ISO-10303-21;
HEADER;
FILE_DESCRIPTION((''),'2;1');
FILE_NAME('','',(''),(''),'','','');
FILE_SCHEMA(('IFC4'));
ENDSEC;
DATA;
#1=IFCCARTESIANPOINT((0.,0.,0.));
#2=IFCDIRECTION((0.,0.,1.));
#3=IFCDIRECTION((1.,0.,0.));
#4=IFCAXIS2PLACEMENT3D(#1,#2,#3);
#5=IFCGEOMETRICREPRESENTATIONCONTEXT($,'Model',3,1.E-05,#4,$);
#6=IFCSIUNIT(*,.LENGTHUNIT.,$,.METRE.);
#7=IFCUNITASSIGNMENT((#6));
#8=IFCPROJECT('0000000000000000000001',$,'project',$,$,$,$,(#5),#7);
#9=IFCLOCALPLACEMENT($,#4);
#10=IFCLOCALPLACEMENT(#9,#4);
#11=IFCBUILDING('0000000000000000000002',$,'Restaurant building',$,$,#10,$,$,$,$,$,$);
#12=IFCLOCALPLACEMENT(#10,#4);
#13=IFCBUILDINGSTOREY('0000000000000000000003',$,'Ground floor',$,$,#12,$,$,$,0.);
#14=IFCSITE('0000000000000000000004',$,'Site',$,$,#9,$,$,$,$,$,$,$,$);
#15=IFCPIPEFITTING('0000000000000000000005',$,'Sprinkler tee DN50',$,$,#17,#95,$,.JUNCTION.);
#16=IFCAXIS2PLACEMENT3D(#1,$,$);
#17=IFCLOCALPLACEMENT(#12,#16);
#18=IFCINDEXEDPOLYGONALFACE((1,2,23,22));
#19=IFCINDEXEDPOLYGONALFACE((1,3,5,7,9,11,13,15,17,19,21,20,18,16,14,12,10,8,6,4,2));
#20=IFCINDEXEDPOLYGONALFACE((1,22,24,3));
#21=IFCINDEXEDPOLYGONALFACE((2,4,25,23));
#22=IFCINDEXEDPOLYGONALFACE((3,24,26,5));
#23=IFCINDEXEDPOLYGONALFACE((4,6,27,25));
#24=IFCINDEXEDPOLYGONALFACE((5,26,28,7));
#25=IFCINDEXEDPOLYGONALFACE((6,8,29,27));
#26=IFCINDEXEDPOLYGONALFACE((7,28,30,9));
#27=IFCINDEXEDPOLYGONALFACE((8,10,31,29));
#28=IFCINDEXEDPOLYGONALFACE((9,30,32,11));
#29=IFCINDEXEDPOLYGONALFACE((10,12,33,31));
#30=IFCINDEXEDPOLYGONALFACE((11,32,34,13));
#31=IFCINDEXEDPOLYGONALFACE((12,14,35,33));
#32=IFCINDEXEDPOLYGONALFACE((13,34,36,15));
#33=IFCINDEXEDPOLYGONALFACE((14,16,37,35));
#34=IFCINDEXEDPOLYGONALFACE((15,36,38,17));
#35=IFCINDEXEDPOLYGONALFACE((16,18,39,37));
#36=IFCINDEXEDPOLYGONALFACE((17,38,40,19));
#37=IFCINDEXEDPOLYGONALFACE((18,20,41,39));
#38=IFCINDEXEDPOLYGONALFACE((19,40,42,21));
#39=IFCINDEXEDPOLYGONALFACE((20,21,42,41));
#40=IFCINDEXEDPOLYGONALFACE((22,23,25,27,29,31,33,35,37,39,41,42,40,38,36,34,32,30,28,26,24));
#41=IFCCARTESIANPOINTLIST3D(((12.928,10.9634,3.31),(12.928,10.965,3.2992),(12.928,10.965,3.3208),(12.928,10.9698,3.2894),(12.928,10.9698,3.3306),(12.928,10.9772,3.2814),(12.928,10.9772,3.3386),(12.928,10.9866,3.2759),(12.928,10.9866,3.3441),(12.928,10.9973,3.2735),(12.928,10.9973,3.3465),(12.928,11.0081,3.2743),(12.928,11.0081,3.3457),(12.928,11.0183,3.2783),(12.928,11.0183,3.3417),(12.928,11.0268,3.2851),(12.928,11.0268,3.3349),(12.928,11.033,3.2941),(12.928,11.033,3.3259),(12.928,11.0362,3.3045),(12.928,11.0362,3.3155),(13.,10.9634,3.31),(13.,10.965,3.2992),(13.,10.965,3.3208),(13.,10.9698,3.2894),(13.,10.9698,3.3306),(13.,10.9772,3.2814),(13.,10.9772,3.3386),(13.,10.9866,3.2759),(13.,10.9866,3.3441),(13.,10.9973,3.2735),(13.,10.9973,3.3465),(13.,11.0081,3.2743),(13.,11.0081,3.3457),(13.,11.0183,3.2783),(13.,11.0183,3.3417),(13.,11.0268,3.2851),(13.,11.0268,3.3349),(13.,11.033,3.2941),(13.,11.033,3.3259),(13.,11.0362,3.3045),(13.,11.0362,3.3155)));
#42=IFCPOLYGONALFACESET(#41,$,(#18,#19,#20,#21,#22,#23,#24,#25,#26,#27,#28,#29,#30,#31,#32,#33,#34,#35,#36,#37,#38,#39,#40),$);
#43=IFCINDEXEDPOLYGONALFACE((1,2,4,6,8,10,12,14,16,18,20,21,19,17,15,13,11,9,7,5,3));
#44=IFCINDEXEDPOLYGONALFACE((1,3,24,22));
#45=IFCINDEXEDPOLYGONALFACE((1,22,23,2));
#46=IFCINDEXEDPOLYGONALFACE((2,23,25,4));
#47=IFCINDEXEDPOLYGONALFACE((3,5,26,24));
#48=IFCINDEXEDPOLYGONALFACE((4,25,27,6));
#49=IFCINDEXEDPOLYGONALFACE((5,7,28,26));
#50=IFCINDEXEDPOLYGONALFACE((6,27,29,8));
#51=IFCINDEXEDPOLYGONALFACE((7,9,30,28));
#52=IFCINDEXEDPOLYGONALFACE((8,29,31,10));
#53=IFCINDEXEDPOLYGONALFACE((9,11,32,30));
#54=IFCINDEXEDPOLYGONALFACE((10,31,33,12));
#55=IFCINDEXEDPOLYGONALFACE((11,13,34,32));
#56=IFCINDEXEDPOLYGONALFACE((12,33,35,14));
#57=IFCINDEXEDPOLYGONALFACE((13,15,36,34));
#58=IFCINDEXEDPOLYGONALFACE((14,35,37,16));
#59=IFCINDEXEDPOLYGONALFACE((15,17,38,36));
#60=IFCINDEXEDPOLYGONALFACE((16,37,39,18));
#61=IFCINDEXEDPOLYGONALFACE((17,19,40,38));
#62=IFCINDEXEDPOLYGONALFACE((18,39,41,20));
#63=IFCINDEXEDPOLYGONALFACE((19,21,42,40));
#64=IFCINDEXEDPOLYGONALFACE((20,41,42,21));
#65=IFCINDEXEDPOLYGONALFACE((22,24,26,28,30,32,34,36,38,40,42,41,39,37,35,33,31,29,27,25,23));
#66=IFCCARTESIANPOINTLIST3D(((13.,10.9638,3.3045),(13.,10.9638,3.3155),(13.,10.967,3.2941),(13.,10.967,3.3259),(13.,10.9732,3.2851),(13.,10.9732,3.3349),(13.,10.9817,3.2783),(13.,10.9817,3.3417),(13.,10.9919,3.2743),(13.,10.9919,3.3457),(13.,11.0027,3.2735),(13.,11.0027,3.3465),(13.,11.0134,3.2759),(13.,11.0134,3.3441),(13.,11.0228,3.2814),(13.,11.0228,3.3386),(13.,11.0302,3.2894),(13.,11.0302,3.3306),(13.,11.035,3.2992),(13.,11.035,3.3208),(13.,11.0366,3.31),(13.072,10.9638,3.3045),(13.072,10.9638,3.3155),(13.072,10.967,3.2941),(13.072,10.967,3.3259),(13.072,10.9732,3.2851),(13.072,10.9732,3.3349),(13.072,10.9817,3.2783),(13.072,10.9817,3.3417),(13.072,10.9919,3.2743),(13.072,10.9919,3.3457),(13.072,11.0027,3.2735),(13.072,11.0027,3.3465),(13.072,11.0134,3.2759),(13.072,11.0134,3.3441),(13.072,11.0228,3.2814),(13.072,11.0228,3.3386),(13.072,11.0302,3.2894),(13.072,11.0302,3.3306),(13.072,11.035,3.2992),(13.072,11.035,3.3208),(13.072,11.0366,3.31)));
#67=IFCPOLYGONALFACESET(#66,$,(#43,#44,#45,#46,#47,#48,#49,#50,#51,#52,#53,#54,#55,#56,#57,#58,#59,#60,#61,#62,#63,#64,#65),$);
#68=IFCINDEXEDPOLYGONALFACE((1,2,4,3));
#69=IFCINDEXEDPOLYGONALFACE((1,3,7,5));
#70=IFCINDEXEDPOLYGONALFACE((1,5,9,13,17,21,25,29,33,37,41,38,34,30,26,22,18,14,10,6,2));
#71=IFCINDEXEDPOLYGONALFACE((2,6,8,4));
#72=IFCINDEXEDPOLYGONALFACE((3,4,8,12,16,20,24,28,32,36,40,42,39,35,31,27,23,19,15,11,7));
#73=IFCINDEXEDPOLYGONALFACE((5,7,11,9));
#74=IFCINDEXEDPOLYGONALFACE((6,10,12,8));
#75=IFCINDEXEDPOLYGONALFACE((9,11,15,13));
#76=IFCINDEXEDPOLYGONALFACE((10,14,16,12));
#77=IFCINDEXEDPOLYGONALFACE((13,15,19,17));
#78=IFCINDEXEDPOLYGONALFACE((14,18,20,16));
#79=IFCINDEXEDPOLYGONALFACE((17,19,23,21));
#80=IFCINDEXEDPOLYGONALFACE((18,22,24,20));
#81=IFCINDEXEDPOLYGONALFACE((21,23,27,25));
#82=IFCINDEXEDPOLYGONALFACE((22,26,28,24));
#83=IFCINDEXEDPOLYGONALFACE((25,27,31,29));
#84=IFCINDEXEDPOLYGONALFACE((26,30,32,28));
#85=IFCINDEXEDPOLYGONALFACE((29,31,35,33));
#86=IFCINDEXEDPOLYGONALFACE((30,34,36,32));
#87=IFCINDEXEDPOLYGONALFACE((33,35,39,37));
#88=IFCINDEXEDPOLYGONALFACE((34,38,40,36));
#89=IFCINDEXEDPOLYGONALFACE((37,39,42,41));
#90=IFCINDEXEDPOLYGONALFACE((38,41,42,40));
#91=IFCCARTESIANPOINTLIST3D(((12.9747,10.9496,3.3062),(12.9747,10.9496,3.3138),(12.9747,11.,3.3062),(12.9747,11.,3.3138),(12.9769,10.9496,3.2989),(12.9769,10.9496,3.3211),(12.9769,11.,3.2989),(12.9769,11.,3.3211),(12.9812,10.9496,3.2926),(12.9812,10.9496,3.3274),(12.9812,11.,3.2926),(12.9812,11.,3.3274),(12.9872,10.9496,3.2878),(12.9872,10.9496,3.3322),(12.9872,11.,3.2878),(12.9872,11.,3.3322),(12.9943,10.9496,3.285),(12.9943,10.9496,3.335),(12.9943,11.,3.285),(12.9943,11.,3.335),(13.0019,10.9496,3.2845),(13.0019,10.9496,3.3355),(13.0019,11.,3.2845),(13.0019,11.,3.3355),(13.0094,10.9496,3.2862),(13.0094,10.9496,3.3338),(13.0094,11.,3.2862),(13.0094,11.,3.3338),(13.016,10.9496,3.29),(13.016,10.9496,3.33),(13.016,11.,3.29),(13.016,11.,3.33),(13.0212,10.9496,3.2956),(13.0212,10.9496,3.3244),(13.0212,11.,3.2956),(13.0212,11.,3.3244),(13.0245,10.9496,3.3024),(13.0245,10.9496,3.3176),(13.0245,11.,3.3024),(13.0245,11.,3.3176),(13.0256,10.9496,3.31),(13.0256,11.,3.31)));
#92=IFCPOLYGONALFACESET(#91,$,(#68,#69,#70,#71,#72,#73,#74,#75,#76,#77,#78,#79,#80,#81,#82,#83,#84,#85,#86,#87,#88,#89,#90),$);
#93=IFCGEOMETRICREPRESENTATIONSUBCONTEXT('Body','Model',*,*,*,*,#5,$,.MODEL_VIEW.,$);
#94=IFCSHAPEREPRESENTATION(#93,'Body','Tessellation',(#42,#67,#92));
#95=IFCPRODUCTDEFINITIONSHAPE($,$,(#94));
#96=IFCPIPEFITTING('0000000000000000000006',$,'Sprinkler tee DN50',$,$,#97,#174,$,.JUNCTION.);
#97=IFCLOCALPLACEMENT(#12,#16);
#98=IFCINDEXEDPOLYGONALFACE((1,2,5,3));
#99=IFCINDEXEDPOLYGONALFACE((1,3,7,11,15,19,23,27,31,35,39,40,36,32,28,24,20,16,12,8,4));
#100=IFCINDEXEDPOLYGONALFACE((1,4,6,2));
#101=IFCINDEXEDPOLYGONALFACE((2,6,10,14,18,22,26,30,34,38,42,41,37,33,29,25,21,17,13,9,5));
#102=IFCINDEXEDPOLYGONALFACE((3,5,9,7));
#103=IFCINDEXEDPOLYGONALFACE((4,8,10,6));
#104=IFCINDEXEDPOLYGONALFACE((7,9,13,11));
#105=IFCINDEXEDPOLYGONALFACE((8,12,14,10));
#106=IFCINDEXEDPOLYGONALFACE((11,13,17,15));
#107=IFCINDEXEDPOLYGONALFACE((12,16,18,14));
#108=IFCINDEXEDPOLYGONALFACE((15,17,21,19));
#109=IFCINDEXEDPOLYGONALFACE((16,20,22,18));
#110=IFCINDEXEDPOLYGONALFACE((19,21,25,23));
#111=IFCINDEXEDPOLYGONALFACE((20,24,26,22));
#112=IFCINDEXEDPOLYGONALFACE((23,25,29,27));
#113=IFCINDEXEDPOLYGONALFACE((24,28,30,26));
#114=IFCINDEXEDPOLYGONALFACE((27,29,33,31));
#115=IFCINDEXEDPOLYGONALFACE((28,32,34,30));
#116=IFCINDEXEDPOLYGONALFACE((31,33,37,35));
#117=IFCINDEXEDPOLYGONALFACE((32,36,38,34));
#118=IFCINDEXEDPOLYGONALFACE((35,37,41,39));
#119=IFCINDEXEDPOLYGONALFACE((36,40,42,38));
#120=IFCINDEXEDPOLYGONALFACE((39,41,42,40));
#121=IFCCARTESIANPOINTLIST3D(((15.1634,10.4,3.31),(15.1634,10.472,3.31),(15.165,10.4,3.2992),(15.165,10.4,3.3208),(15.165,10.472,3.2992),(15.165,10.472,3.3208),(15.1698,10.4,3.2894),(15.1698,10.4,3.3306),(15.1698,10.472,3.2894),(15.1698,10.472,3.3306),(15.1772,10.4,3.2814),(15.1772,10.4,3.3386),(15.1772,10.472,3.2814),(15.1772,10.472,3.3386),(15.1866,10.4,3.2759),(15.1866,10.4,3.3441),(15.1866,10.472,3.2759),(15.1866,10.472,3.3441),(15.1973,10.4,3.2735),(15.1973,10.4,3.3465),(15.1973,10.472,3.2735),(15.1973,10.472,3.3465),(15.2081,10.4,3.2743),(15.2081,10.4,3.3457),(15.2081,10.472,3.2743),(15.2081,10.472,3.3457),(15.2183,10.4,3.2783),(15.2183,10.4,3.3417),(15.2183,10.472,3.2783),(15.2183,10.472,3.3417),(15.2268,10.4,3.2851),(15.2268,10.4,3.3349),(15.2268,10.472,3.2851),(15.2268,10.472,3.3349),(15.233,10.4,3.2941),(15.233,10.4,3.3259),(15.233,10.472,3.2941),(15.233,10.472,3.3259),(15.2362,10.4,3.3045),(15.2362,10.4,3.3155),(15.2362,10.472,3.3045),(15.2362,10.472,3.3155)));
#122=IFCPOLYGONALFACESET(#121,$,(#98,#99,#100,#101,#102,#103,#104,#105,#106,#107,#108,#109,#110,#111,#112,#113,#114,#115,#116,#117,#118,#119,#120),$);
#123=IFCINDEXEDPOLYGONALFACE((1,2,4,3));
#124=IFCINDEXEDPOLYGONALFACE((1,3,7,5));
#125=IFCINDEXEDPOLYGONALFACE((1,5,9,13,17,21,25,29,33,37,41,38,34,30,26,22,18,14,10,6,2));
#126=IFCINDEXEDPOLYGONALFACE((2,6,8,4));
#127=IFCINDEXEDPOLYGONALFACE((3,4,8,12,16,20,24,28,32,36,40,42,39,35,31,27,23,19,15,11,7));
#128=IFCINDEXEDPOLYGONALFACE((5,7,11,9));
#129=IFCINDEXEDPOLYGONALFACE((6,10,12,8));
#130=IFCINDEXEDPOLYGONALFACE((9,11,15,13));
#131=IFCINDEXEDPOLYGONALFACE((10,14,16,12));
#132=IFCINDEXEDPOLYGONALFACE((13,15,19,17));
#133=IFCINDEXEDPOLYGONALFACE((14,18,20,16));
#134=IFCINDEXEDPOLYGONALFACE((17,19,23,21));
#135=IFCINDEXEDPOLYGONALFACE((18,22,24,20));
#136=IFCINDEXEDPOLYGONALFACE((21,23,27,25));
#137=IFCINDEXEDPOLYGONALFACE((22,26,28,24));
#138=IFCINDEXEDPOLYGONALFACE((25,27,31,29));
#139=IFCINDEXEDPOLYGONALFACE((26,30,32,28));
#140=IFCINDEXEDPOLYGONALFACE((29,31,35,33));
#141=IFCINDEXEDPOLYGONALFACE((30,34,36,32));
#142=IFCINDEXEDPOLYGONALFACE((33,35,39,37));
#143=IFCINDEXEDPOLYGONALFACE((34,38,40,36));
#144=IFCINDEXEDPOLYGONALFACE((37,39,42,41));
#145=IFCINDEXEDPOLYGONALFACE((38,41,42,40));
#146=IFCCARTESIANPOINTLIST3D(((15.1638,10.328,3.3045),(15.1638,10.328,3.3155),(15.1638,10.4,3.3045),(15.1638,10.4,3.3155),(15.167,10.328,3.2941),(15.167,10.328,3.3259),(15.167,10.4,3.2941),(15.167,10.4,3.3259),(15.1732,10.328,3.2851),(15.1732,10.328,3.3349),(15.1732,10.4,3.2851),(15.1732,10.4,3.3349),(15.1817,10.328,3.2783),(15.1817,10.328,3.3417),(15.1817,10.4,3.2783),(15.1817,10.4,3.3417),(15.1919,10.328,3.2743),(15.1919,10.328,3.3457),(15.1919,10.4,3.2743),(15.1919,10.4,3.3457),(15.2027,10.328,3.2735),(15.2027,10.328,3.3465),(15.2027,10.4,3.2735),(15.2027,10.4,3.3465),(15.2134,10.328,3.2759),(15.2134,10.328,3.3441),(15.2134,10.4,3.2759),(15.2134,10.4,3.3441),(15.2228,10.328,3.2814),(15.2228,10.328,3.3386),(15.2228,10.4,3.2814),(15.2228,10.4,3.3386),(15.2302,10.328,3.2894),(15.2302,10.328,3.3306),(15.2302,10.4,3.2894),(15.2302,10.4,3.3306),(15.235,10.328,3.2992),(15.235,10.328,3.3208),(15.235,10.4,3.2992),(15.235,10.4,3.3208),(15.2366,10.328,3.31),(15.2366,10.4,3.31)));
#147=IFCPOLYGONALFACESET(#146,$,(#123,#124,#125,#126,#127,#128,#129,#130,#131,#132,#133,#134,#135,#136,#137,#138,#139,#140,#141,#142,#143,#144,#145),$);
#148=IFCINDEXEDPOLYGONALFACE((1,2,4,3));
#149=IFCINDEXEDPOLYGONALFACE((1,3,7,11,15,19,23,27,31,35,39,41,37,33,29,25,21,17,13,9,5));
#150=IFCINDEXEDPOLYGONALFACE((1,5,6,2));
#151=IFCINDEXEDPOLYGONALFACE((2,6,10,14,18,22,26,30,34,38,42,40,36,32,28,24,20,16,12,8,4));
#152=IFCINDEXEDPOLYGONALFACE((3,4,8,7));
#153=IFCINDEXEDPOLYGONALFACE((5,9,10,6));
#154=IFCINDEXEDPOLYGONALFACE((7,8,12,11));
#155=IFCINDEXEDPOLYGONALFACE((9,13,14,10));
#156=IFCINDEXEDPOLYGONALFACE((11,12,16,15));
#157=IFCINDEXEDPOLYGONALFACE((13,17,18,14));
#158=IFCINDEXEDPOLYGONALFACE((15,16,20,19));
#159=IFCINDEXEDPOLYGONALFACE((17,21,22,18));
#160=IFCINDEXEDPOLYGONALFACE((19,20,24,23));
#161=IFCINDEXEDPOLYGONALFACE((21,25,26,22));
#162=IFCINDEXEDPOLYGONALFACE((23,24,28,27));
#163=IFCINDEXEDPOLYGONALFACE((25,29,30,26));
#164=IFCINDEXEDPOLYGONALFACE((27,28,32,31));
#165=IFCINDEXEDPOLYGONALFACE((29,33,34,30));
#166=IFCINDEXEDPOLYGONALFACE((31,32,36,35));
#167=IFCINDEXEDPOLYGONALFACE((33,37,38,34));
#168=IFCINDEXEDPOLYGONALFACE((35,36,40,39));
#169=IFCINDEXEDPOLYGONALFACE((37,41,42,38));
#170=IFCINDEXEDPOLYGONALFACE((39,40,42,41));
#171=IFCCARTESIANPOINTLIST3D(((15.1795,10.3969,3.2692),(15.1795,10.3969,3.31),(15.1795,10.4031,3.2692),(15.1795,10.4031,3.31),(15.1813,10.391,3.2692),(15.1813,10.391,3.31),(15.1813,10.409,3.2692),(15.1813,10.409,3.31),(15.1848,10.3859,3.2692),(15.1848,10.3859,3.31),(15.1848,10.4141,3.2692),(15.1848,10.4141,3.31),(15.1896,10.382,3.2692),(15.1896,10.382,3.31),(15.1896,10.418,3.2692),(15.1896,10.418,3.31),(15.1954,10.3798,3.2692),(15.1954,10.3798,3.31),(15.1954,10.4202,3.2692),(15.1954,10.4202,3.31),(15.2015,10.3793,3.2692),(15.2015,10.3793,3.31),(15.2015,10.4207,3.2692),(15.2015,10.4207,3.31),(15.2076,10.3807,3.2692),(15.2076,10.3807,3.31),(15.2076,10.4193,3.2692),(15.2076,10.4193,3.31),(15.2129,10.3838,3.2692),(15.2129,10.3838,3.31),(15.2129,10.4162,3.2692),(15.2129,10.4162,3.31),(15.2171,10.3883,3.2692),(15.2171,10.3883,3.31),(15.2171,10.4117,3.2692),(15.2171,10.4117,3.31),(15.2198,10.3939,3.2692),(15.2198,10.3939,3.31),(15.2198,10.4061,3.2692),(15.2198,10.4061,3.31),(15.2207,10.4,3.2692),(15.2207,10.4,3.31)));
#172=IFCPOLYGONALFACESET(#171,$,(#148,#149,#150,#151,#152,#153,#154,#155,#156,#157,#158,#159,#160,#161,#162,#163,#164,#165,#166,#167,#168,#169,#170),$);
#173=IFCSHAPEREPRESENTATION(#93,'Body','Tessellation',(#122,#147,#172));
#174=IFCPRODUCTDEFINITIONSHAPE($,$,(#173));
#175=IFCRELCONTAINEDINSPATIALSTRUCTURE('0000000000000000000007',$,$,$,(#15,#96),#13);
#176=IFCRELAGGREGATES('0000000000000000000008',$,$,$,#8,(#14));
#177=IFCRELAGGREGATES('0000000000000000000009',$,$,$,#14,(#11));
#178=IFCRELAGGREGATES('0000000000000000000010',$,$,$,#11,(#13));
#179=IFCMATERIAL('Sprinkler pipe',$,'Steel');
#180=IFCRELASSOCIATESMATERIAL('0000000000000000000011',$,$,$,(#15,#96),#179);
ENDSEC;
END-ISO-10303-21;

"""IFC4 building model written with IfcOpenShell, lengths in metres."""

from ifc_helpers import new_model, si_unit, frame, origin_with_axes, origin_2d, place, context, subcontext, project, spatial, circle, extrude, material, element, save


model = new_model("IFC4")

# Units and contexts
model_context = context("Model", 3, precision=1e-05, world=origin_with_axes())
body_context = subcontext(model_context, "Body", "Model", "MODEL_VIEW")
ifc_project = project(units=[si_unit("LENGTHUNIT", "METRE")], contexts=[model_context])

# Site, building, storey
site_placement = place(None, origin_with_axes())
site = spatial("IfcSite", under=ifc_project, at=site_placement, Name="Site")
building_placement = place(site_placement, origin_with_axes())
building = spatial("IfcBuilding", under=site, at=building_placement, Name="Restaurant building")
storey_placement = place(building_placement, origin_with_axes())
storey = spatial("IfcBuildingStorey", under=building, at=storey_placement, Name="Ground floor", Elevation=0.0)

# Shared definitions
ifc_material_1 = material(Name="Sprinkler pipe", Category="Steel")

# Pipe fittings
pipe_fitting_1_placement = place(storey_placement, frame((13.0, 11.0, 3.31)))
element("IfcPipeFitting", 1, at=pipe_fitting_1_placement, inside=storey, material=ifc_material_1, Name="Sprinkler tee DN50", PredefinedType="JUNCTION", context=body_context, shape_type="SweptSolid", body=[
    extrude(circle(Radius=0.0366, at=origin_2d()), frame((0.0, 0.0, 0.0), z_axis=(-1.0, 0.0, 0.0), x_axis=(0.0, -1.0, 0.0)), (0.0, 0.0, 1.0), 0.072),
    extrude(circle(Radius=0.0366, at=origin_2d()), frame((0.0, 0.0, 0.0), z_axis=(1.0, 0.0, 0.0), x_axis=(0.0, 1.0, 0.0)), (0.0, 0.0, 1.0), 0.072),
    extrude(circle(Radius=0.0256, at=origin_2d()), frame((0.0, 0.0, 0.0), z_axis=(0.0, -1.0, 0.0), x_axis=(1.0, 0.0, 0.0)), (0.0, 0.0, 1.0), 0.0504),
])
pipe_fitting_2_placement = place(storey_placement, frame((15.2, 10.4, 3.31)))
element("IfcPipeFitting", 2, at=pipe_fitting_2_placement, inside=storey, material=ifc_material_1, Name="Sprinkler tee DN50", PredefinedType="JUNCTION", context=body_context, shape_type="SweptSolid", body=[
    extrude(circle(Radius=0.0366, at=origin_2d()), frame((0.0, 0.0, 0.0), z_axis=(0.0, 1.0, 0.0), x_axis=(-1.0, 0.0, 0.0)), (0.0, 0.0, 1.0), 0.072),
    extrude(circle(Radius=0.0366, at=origin_2d()), frame((0.0, 0.0, 0.0), z_axis=(0.0, -1.0, 0.0), x_axis=(1.0, 0.0, 0.0)), (0.0, 0.0, 1.0), 0.072),
    extrude(circle(Radius=0.0207, at=origin_2d()), frame((0.0, 0.0, 0.0), z_axis=(0.0, 0.0, -1.0), x_axis=(1.0, 0.0, 0.0)), (0.0, 0.0, 1.0), 0.0408),
])

save(model, "model.ifc")
